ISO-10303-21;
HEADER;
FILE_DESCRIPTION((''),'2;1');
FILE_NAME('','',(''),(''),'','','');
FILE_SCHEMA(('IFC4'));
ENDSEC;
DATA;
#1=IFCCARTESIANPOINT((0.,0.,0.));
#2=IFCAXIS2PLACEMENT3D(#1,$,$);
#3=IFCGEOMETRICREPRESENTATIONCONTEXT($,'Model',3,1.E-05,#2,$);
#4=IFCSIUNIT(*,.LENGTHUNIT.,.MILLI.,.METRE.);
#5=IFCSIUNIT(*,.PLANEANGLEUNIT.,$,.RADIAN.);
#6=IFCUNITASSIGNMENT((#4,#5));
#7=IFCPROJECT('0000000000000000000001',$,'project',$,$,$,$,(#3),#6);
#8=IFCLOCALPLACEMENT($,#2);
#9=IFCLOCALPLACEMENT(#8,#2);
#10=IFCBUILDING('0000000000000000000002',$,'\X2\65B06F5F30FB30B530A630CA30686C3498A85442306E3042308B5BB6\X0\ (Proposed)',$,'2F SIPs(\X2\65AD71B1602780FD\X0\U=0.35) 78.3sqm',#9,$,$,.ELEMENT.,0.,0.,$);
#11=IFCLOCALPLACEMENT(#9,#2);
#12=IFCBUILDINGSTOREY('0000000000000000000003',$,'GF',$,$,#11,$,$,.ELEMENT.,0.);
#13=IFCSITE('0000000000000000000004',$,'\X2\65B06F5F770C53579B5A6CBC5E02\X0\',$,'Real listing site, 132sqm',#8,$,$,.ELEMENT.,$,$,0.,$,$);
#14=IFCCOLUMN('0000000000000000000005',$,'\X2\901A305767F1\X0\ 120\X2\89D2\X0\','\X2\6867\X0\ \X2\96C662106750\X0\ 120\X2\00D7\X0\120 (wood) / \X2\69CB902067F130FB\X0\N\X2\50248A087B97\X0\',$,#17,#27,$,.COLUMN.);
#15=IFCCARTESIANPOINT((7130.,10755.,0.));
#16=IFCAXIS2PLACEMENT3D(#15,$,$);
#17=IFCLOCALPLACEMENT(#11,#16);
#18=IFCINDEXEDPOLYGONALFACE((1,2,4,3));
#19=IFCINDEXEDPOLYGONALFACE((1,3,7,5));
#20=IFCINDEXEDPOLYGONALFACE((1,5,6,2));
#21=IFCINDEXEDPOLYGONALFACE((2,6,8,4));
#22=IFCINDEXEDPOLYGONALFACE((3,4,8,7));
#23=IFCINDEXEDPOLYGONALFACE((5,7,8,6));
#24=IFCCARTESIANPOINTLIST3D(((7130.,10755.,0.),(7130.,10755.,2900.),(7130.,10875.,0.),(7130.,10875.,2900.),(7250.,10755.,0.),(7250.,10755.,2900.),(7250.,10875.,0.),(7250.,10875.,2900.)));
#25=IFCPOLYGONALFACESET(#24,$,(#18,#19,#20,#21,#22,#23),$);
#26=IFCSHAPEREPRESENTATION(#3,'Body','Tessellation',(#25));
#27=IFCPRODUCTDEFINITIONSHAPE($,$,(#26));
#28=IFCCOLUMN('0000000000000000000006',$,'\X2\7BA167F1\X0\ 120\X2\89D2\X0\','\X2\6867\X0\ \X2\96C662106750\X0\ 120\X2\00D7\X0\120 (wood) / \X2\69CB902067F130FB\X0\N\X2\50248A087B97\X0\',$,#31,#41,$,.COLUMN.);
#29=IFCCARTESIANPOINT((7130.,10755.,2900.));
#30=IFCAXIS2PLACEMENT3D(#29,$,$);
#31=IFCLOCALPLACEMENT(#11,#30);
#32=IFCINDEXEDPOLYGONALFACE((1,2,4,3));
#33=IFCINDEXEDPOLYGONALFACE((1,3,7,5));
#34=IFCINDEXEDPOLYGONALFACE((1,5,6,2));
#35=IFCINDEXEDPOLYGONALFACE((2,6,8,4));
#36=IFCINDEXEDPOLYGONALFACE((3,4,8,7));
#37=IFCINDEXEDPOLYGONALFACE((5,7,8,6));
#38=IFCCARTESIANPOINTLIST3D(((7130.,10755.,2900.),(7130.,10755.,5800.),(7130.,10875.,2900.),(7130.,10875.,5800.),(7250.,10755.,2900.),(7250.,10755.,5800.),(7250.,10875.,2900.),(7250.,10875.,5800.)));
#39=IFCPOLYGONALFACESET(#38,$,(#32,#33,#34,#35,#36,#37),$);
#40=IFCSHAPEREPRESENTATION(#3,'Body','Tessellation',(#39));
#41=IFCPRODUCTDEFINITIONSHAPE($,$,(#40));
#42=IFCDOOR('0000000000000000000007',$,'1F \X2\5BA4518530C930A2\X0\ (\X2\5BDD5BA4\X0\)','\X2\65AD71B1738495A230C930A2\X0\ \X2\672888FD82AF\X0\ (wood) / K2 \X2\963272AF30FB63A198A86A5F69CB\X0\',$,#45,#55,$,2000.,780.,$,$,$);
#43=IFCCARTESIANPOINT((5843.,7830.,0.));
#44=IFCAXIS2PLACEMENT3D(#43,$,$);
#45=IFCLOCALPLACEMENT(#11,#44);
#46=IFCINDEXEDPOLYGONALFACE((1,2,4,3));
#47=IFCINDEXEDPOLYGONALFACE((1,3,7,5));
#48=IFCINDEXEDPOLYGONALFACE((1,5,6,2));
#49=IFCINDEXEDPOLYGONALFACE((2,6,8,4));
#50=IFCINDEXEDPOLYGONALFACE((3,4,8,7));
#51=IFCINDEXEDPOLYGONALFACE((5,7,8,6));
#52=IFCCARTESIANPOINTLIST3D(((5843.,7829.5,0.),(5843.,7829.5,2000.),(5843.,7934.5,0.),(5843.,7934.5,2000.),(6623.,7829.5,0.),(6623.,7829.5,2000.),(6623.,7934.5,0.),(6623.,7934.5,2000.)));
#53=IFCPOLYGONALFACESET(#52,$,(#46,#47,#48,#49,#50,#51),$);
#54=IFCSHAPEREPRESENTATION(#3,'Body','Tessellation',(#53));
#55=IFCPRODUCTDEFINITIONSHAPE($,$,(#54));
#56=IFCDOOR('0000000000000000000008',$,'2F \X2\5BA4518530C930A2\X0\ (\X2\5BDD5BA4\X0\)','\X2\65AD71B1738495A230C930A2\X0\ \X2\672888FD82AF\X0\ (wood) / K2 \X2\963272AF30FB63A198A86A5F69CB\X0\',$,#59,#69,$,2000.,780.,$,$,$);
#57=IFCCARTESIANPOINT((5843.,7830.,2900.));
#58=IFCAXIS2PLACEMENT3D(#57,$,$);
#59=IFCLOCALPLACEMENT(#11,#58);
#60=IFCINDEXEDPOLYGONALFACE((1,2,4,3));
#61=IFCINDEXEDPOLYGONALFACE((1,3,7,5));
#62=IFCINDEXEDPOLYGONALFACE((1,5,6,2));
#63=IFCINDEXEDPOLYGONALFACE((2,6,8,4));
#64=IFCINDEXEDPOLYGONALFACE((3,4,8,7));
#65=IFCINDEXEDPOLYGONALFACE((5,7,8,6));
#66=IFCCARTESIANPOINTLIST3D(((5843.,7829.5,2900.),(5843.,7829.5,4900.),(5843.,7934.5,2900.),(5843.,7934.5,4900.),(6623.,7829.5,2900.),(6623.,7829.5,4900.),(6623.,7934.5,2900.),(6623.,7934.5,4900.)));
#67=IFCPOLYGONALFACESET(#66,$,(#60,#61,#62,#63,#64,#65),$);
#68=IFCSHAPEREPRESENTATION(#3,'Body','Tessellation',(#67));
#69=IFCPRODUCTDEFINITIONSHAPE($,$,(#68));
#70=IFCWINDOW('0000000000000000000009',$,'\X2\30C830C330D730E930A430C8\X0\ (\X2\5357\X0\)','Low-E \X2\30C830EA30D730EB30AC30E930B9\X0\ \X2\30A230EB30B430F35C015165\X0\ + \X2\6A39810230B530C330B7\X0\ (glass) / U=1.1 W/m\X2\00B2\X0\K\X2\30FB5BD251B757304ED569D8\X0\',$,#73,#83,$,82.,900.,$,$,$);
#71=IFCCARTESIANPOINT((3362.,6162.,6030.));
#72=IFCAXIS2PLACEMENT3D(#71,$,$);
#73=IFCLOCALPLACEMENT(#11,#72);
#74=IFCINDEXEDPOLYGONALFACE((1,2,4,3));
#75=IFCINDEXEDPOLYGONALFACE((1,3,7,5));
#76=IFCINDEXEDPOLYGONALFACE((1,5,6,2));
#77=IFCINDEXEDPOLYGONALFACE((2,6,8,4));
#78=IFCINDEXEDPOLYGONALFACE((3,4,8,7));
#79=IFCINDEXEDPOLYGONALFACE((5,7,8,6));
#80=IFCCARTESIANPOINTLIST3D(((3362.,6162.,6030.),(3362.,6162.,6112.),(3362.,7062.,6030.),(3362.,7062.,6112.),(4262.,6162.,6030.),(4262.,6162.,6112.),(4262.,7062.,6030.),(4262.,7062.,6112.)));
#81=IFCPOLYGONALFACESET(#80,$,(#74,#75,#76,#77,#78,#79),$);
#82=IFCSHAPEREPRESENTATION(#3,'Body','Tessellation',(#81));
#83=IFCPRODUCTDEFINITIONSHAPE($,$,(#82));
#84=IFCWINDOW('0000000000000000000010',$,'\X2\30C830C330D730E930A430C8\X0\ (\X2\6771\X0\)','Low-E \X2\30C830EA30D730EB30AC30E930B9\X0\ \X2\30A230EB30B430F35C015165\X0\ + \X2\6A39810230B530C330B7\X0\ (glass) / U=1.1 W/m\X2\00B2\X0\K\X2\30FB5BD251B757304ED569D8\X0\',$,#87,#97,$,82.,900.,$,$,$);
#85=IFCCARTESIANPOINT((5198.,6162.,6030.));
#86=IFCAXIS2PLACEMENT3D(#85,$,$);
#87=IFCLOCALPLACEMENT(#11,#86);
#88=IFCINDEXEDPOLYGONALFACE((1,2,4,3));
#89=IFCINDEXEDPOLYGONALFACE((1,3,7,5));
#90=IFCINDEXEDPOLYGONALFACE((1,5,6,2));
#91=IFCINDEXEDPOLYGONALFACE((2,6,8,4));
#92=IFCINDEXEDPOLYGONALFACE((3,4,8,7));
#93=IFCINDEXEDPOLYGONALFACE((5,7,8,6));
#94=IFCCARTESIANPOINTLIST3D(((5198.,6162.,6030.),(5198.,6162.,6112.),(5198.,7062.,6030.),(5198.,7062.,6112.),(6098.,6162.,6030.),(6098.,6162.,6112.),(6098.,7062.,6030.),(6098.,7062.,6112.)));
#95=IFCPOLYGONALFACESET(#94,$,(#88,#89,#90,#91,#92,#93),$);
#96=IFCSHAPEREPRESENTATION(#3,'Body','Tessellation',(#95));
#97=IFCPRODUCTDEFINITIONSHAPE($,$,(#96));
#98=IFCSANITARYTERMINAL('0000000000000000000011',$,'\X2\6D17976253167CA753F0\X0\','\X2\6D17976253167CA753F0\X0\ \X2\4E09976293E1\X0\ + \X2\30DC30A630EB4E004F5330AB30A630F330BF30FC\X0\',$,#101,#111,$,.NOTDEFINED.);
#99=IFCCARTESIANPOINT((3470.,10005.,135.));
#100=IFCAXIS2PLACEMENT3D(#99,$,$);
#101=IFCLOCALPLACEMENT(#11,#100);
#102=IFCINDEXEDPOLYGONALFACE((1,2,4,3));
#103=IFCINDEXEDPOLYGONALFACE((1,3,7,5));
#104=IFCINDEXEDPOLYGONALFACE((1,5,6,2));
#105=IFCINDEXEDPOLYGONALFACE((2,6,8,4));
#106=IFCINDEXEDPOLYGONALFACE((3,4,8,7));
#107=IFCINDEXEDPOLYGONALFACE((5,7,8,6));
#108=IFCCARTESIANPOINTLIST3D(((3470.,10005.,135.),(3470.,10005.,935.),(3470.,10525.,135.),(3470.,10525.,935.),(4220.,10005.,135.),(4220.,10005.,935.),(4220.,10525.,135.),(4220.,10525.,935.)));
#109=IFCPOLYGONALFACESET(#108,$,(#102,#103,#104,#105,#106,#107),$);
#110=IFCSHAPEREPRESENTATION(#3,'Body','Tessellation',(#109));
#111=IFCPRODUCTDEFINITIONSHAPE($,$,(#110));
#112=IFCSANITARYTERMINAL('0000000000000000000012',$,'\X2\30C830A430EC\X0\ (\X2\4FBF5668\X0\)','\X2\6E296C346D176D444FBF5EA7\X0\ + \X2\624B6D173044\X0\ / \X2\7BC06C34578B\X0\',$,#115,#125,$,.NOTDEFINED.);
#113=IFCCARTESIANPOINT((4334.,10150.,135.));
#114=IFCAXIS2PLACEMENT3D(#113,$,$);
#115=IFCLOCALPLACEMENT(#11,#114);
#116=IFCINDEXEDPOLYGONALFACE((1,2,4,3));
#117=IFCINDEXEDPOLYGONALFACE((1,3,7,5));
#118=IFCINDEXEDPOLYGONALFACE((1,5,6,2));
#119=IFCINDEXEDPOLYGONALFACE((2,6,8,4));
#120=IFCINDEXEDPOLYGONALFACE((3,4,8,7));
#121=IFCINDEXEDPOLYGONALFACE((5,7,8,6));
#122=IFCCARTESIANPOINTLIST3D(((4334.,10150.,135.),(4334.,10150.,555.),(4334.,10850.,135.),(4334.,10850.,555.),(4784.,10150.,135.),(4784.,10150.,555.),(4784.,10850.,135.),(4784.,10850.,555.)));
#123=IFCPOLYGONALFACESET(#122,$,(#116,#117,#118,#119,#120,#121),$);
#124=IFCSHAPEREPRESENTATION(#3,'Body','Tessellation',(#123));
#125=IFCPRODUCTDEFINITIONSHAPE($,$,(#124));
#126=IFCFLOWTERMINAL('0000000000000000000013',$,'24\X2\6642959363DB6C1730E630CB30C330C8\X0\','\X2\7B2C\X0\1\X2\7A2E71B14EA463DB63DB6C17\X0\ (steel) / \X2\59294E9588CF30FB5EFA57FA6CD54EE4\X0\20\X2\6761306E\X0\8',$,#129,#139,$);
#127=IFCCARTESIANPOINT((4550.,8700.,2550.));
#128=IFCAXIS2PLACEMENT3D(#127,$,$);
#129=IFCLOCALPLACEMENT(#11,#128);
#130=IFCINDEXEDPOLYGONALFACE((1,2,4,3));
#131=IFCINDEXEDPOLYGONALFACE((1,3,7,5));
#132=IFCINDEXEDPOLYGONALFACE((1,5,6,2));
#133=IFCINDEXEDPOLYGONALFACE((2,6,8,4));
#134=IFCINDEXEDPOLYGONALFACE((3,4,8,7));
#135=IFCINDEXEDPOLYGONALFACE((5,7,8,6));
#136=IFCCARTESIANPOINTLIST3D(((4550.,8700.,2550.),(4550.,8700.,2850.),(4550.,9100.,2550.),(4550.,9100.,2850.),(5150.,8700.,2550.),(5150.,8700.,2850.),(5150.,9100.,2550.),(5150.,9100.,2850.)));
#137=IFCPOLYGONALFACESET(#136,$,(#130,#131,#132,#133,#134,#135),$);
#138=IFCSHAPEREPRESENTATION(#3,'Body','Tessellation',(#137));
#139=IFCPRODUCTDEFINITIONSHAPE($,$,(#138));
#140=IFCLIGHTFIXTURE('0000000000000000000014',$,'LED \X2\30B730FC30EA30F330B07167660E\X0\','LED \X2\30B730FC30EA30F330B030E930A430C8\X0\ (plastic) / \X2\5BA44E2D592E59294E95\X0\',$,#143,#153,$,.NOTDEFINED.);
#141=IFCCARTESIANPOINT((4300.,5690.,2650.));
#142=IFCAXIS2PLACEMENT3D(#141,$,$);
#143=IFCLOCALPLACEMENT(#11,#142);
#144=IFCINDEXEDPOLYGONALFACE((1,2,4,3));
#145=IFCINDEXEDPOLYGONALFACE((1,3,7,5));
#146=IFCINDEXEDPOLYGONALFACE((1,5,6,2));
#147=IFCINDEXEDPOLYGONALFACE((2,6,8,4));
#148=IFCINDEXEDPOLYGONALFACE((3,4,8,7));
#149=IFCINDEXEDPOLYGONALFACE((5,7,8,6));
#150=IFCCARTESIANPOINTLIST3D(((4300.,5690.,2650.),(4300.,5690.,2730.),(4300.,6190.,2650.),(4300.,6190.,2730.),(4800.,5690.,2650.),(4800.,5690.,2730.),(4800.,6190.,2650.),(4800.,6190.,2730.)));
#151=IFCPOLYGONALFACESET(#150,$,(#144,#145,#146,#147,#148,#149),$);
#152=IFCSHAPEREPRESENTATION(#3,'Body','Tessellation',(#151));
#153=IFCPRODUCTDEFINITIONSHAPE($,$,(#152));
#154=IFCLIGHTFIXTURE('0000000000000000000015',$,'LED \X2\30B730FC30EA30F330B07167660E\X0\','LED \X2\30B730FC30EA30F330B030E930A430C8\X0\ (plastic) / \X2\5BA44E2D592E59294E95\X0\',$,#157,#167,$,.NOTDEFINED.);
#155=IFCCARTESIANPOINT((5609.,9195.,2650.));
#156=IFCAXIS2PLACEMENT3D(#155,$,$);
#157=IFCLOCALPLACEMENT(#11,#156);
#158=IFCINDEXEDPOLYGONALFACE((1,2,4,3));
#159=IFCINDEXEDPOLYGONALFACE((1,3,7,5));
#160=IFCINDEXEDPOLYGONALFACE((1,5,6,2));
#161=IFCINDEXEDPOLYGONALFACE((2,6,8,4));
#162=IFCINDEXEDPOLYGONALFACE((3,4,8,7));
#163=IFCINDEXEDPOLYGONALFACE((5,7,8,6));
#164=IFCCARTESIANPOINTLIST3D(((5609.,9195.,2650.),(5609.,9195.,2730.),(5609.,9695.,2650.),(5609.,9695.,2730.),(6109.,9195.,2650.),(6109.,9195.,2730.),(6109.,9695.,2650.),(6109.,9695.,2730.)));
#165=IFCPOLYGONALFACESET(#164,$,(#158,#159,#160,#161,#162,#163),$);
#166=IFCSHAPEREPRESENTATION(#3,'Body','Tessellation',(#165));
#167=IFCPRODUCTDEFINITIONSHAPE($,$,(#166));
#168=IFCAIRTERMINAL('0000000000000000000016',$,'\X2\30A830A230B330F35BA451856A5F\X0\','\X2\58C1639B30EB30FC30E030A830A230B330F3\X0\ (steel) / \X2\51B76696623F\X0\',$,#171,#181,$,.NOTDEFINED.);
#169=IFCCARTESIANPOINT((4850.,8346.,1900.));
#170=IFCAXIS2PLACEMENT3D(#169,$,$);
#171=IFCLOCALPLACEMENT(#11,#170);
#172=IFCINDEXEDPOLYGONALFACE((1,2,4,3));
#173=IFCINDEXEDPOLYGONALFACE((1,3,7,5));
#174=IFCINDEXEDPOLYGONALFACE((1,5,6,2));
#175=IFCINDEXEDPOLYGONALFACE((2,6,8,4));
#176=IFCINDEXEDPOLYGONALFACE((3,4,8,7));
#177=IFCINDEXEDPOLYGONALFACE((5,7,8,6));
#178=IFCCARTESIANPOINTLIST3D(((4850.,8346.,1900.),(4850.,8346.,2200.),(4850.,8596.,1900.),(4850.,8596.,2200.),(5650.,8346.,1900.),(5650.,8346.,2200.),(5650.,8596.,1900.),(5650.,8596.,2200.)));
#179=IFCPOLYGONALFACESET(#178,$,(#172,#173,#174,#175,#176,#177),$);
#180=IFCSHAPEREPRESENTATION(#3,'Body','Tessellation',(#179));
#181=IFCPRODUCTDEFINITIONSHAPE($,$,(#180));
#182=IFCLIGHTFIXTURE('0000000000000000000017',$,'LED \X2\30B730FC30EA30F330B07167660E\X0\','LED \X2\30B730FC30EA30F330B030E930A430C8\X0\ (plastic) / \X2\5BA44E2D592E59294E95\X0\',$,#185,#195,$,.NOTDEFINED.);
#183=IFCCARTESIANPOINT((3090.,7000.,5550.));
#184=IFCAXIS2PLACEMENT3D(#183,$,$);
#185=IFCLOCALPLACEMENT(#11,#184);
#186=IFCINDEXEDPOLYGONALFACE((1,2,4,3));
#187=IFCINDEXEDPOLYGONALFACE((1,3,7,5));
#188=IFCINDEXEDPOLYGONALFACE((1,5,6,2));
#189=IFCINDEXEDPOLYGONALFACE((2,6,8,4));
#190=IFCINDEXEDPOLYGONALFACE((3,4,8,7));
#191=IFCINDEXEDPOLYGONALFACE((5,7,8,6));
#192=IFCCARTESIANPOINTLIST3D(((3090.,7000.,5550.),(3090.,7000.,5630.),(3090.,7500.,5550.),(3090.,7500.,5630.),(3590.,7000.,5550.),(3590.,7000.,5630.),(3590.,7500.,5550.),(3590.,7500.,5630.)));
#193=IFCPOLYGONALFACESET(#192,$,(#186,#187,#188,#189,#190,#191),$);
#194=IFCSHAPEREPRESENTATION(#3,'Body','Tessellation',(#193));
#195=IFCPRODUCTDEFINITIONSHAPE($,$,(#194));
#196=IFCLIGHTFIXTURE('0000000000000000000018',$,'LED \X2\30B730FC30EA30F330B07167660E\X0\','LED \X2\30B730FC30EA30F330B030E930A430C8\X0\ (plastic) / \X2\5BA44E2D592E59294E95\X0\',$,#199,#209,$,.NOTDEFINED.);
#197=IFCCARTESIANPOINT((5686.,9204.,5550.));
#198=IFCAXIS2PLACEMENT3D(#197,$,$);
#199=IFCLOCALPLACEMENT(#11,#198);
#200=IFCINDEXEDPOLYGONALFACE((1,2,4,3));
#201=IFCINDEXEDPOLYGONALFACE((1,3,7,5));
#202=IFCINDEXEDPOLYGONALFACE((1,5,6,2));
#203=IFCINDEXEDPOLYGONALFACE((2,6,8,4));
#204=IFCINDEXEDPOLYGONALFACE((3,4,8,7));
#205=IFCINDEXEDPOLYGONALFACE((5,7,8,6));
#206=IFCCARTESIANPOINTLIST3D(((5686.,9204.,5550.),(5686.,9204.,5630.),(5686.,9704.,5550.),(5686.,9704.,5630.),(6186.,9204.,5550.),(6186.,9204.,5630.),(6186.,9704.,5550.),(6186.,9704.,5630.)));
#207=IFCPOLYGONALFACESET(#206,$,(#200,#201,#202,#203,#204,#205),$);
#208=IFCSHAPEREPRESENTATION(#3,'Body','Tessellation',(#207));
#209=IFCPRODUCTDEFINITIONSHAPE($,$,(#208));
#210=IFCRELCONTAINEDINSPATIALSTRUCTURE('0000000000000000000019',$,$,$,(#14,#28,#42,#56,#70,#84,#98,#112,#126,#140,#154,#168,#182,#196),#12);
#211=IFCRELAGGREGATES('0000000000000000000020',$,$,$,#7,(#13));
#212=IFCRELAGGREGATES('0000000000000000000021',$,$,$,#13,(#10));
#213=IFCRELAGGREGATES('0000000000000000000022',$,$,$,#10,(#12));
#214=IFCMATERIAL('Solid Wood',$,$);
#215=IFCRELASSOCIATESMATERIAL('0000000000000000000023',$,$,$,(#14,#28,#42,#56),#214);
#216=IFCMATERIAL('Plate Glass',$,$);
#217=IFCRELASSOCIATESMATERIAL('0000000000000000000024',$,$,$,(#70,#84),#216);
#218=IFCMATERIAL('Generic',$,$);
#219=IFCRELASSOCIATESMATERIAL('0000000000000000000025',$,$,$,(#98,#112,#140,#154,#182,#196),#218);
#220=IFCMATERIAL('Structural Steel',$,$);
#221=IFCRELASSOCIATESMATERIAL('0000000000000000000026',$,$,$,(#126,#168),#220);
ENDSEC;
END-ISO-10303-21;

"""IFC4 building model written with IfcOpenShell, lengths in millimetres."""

from ifc_helpers import new_model, si_unit, frame, frame_2d, origin, place, context, project, spatial, rectangle, extrude, material, element, save


model = new_model("IFC4")

# Units and contexts
model_context = context("Model", 3, precision=1e-05, world=origin())
ifc_project = project(units=[si_unit("LENGTHUNIT", "METRE", prefix="MILLI"), si_unit("PLANEANGLEUNIT", "RADIAN")], contexts=[model_context])

# Site, building, storey
site_placement = place(None, origin())
site = spatial("IfcSite", under=ifc_project, at=site_placement, Name="新潟県南魚沼市", ObjectType="Real listing site, 132sqm", CompositionType="ELEMENT", RefElevation=0.0)
building_placement = place(site_placement, origin())
building = spatial("IfcBuilding", under=site, at=building_placement, Name="新潟・サウナと水風呂のある家 (Proposed)", ObjectType="2F SIPs(断熱性能U=0.35) 78.3sqm", CompositionType="ELEMENT", ElevationOfRefHeight=0.0, ElevationOfTerrain=0.0)
storey_placement = place(building_placement, origin())
storey = spatial("IfcBuildingStorey", under=building, at=storey_placement, Name="GF", CompositionType="ELEMENT", Elevation=0.0)

# Columns
ifc_material_1 = material(Name="Solid Wood")
column_1_placement = place(storey_placement, frame((7130.0, 10755.0, 0.0)))
element("IfcColumn", 1, at=column_1_placement, inside=storey, material=ifc_material_1, Name="通し柱 120角", Description="桧 集成材 120×120 (wood) / 構造柱・N値計算", PredefinedType="COLUMN", context=model_context, shape_type="SweptSolid", body=[
    extrude(rectangle(XDim=120.0, YDim=120.0, at=frame_2d((60.0, 60.0))), frame((7130.0, 10755.0, 0.0)), (0.0, 0.0, 1.0), 2900.0),
])
column_2_placement = place(storey_placement, frame((7130.0, 10755.0, 2900.0)))
element("IfcColumn", 2, at=column_2_placement, inside=storey, material=ifc_material_1, Name="管柱 120角", Description="桧 集成材 120×120 (wood) / 構造柱・N値計算", PredefinedType="COLUMN", context=model_context, shape_type="SweptSolid", body=[
    extrude(rectangle(XDim=120.0, YDim=120.0, at=frame_2d((60.0, 60.0))), frame((7130.0, 10755.0, 2900.0)), (0.0, 0.0, 1.0), 2900.0),
])

# Door
door_1_placement = place(storey_placement, frame((5843.0, 7830.0, 0.0)))
element("IfcDoor", 3, at=door_1_placement, inside=storey, material=ifc_material_1, Name="1F 室内ドア (寝室)", Description="断熱玄関ドア 木製芯 (wood) / K2 防犯・採風機構", OverallHeight=2000.0, OverallWidth=780.0, context=model_context, shape_type="SweptSolid", body=[
    extrude(rectangle(XDim=780.0, YDim=105.0, at=frame_2d((390.0, 52.0))), frame((5843.0, 7830.0, 0.0)), (0.0, 0.0, 1.0), 2000.0),
])

# Door
door_2_placement = place(storey_placement, frame((5843.0, 7830.0, 2900.0)))
element("IfcDoor", 4, at=door_2_placement, inside=storey, material=ifc_material_1, Name="2F 室内ドア (寝室)", Description="断熱玄関ドア 木製芯 (wood) / K2 防犯・採風機構", OverallHeight=2000.0, OverallWidth=780.0, context=model_context, shape_type="SweptSolid", body=[
    extrude(rectangle(XDim=780.0, YDim=105.0, at=frame_2d((390.0, 52.0))), frame((5843.0, 7830.0, 2900.0)), (0.0, 0.0, 1.0), 2000.0),
])

# Windows
ifc_material_2 = material(Name="Plate Glass")
window_1_placement = place(storey_placement, frame((3362.0, 6162.0, 6030.0)))
element("IfcWindow", 5, at=window_1_placement, inside=storey, material=ifc_material_2, Name="トップライト (南)", Description="Low-E トリプルガラス アルゴン封入 + 樹脂サッシ (glass) / U=1.1 W/m²K・寒冷地仕様", OverallHeight=82.0, OverallWidth=900.0, context=model_context, shape_type="SweptSolid", body=[
    extrude(rectangle(XDim=900.0, YDim=900.0, at=frame_2d((450.0, 450.0))), frame((3362.0, 6162.0, 6030.0)), (0.0, 0.0, 1.0), 82.0),
])
window_2_placement = place(storey_placement, frame((5198.0, 6162.0, 6030.0)))
element("IfcWindow", 6, at=window_2_placement, inside=storey, material=ifc_material_2, Name="トップライト (東)", Description="Low-E トリプルガラス アルゴン封入 + 樹脂サッシ (glass) / U=1.1 W/m²K・寒冷地仕様", OverallHeight=82.0, OverallWidth=900.0, context=model_context, shape_type="SweptSolid", body=[
    extrude(rectangle(XDim=900.0, YDim=900.0, at=frame_2d((450.0, 450.0))), frame((5198.0, 6162.0, 6030.0)), (0.0, 0.0, 1.0), 82.0),
])

# Sanitary terminals
ifc_material_3 = material(Name="Generic")
sanitary_terminal_1_placement = place(storey_placement, frame((3470.0, 10005.0, 135.0)))
element("IfcSanitaryTerminal", 7, at=sanitary_terminal_1_placement, inside=storey, material=ifc_material_3, Name="洗面化粧台", Description="洗面化粧台 三面鏡 + ボウル一体カウンター", PredefinedType="NOTDEFINED", context=model_context, shape_type="SweptSolid", body=[
    extrude(rectangle(XDim=750.0, YDim=520.0, at=frame_2d((375.0, 260.0))), frame((3470.0, 10005.0, 135.0)), (0.0, 0.0, 1.0), 800.0),
])
sanitary_terminal_2_placement = place(storey_placement, frame((4334.0, 10150.0, 135.0)))
element("IfcSanitaryTerminal", 8, at=sanitary_terminal_2_placement, inside=storey, material=ifc_material_3, Name="トイレ (便器)", Description="温水洗浄便座 + 手洗い / 節水型", PredefinedType="NOTDEFINED", context=model_context, shape_type="SweptSolid", body=[
    extrude(rectangle(XDim=450.0, YDim=700.0, at=frame_2d((225.0, 350.0))), frame((4334.0, 10150.0, 135.0)), (0.0, 0.0, 1.0), 420.0),
])

# Flow terminal
ifc_material_4 = material(Name="Structural Steel")
flow_terminal_placement = place(storey_placement, frame((4550.0, 8700.0, 2550.0)))
element("IfcFlowTerminal", 9, at=flow_terminal_placement, inside=storey, material=ifc_material_4, Name="24時間換気ユニット", Description="第1種熱交換換気 (steel) / 天井裏・建基法令20条の8", context=model_context, shape_type="SweptSolid", body=[
    extrude(rectangle(XDim=600.0, YDim=400.0, at=frame_2d((300.0, 200.0))), frame((4550.0, 8700.0, 2550.0)), (0.0, 0.0, 1.0), 300.0),
])

# Light fixtures
light_fixture_1_placement = place(storey_placement, frame((4300.0, 5690.0, 2650.0)))
element("IfcLightFixture", 10, at=light_fixture_1_placement, inside=storey, material=ifc_material_3, Name="LED シーリング照明", Description="LED シーリングライト (plastic) / 室中央天井", PredefinedType="NOTDEFINED", context=model_context, shape_type="SweptSolid", body=[
    extrude(rectangle(XDim=500.0, YDim=500.0, at=frame_2d((250.0, 250.0))), frame((4300.0, 5690.0, 2650.0)), (0.0, 0.0, 1.0), 80.0),
])
light_fixture_2_placement = place(storey_placement, frame((5609.0, 9195.0, 2650.0)))
element("IfcLightFixture", 11, at=light_fixture_2_placement, inside=storey, material=ifc_material_3, Name="LED シーリング照明", Description="LED シーリングライト (plastic) / 室中央天井", PredefinedType="NOTDEFINED", context=model_context, shape_type="SweptSolid", body=[
    extrude(rectangle(XDim=500.0, YDim=500.0, at=frame_2d((250.0, 250.0))), frame((5609.0, 9195.0, 2650.0)), (0.0, 0.0, 1.0), 80.0),
])

# Air terminal
air_terminal_placement = place(storey_placement, frame((4850.0, 8346.0, 1900.0)))
element("IfcAirTerminal", 12, at=air_terminal_placement, inside=storey, material=ifc_material_4, Name="エアコン室内機", Description="壁掛ルームエアコン (steel) / 冷暖房", PredefinedType="NOTDEFINED", context=model_context, shape_type="SweptSolid", body=[
    extrude(rectangle(XDim=800.0, YDim=250.0, at=frame_2d((400.0, 125.0))), frame((4850.0, 8346.0, 1900.0)), (0.0, 0.0, 1.0), 300.0),
])

# Light fixtures
light_fixture_3_placement = place(storey_placement, frame((3090.0, 7000.0, 5550.0)))
element("IfcLightFixture", 13, at=light_fixture_3_placement, inside=storey, material=ifc_material_3, Name="LED シーリング照明", Description="LED シーリングライト (plastic) / 室中央天井", PredefinedType="NOTDEFINED", context=model_context, shape_type="SweptSolid", body=[
    extrude(rectangle(XDim=500.0, YDim=500.0, at=frame_2d((250.0, 250.0))), frame((3090.0, 7000.0, 5550.0)), (0.0, 0.0, 1.0), 80.0),
])
light_fixture_4_placement = place(storey_placement, frame((5686.0, 9204.0, 5550.0)))
element("IfcLightFixture", 14, at=light_fixture_4_placement, inside=storey, material=ifc_material_3, Name="LED シーリング照明", Description="LED シーリングライト (plastic) / 室中央天井", PredefinedType="NOTDEFINED", context=model_context, shape_type="SweptSolid", body=[
    extrude(rectangle(XDim=500.0, YDim=500.0, at=frame_2d((250.0, 250.0))), frame((5686.0, 9204.0, 5550.0)), (0.0, 0.0, 1.0), 80.0),
])

save(model, "model.ifc")
